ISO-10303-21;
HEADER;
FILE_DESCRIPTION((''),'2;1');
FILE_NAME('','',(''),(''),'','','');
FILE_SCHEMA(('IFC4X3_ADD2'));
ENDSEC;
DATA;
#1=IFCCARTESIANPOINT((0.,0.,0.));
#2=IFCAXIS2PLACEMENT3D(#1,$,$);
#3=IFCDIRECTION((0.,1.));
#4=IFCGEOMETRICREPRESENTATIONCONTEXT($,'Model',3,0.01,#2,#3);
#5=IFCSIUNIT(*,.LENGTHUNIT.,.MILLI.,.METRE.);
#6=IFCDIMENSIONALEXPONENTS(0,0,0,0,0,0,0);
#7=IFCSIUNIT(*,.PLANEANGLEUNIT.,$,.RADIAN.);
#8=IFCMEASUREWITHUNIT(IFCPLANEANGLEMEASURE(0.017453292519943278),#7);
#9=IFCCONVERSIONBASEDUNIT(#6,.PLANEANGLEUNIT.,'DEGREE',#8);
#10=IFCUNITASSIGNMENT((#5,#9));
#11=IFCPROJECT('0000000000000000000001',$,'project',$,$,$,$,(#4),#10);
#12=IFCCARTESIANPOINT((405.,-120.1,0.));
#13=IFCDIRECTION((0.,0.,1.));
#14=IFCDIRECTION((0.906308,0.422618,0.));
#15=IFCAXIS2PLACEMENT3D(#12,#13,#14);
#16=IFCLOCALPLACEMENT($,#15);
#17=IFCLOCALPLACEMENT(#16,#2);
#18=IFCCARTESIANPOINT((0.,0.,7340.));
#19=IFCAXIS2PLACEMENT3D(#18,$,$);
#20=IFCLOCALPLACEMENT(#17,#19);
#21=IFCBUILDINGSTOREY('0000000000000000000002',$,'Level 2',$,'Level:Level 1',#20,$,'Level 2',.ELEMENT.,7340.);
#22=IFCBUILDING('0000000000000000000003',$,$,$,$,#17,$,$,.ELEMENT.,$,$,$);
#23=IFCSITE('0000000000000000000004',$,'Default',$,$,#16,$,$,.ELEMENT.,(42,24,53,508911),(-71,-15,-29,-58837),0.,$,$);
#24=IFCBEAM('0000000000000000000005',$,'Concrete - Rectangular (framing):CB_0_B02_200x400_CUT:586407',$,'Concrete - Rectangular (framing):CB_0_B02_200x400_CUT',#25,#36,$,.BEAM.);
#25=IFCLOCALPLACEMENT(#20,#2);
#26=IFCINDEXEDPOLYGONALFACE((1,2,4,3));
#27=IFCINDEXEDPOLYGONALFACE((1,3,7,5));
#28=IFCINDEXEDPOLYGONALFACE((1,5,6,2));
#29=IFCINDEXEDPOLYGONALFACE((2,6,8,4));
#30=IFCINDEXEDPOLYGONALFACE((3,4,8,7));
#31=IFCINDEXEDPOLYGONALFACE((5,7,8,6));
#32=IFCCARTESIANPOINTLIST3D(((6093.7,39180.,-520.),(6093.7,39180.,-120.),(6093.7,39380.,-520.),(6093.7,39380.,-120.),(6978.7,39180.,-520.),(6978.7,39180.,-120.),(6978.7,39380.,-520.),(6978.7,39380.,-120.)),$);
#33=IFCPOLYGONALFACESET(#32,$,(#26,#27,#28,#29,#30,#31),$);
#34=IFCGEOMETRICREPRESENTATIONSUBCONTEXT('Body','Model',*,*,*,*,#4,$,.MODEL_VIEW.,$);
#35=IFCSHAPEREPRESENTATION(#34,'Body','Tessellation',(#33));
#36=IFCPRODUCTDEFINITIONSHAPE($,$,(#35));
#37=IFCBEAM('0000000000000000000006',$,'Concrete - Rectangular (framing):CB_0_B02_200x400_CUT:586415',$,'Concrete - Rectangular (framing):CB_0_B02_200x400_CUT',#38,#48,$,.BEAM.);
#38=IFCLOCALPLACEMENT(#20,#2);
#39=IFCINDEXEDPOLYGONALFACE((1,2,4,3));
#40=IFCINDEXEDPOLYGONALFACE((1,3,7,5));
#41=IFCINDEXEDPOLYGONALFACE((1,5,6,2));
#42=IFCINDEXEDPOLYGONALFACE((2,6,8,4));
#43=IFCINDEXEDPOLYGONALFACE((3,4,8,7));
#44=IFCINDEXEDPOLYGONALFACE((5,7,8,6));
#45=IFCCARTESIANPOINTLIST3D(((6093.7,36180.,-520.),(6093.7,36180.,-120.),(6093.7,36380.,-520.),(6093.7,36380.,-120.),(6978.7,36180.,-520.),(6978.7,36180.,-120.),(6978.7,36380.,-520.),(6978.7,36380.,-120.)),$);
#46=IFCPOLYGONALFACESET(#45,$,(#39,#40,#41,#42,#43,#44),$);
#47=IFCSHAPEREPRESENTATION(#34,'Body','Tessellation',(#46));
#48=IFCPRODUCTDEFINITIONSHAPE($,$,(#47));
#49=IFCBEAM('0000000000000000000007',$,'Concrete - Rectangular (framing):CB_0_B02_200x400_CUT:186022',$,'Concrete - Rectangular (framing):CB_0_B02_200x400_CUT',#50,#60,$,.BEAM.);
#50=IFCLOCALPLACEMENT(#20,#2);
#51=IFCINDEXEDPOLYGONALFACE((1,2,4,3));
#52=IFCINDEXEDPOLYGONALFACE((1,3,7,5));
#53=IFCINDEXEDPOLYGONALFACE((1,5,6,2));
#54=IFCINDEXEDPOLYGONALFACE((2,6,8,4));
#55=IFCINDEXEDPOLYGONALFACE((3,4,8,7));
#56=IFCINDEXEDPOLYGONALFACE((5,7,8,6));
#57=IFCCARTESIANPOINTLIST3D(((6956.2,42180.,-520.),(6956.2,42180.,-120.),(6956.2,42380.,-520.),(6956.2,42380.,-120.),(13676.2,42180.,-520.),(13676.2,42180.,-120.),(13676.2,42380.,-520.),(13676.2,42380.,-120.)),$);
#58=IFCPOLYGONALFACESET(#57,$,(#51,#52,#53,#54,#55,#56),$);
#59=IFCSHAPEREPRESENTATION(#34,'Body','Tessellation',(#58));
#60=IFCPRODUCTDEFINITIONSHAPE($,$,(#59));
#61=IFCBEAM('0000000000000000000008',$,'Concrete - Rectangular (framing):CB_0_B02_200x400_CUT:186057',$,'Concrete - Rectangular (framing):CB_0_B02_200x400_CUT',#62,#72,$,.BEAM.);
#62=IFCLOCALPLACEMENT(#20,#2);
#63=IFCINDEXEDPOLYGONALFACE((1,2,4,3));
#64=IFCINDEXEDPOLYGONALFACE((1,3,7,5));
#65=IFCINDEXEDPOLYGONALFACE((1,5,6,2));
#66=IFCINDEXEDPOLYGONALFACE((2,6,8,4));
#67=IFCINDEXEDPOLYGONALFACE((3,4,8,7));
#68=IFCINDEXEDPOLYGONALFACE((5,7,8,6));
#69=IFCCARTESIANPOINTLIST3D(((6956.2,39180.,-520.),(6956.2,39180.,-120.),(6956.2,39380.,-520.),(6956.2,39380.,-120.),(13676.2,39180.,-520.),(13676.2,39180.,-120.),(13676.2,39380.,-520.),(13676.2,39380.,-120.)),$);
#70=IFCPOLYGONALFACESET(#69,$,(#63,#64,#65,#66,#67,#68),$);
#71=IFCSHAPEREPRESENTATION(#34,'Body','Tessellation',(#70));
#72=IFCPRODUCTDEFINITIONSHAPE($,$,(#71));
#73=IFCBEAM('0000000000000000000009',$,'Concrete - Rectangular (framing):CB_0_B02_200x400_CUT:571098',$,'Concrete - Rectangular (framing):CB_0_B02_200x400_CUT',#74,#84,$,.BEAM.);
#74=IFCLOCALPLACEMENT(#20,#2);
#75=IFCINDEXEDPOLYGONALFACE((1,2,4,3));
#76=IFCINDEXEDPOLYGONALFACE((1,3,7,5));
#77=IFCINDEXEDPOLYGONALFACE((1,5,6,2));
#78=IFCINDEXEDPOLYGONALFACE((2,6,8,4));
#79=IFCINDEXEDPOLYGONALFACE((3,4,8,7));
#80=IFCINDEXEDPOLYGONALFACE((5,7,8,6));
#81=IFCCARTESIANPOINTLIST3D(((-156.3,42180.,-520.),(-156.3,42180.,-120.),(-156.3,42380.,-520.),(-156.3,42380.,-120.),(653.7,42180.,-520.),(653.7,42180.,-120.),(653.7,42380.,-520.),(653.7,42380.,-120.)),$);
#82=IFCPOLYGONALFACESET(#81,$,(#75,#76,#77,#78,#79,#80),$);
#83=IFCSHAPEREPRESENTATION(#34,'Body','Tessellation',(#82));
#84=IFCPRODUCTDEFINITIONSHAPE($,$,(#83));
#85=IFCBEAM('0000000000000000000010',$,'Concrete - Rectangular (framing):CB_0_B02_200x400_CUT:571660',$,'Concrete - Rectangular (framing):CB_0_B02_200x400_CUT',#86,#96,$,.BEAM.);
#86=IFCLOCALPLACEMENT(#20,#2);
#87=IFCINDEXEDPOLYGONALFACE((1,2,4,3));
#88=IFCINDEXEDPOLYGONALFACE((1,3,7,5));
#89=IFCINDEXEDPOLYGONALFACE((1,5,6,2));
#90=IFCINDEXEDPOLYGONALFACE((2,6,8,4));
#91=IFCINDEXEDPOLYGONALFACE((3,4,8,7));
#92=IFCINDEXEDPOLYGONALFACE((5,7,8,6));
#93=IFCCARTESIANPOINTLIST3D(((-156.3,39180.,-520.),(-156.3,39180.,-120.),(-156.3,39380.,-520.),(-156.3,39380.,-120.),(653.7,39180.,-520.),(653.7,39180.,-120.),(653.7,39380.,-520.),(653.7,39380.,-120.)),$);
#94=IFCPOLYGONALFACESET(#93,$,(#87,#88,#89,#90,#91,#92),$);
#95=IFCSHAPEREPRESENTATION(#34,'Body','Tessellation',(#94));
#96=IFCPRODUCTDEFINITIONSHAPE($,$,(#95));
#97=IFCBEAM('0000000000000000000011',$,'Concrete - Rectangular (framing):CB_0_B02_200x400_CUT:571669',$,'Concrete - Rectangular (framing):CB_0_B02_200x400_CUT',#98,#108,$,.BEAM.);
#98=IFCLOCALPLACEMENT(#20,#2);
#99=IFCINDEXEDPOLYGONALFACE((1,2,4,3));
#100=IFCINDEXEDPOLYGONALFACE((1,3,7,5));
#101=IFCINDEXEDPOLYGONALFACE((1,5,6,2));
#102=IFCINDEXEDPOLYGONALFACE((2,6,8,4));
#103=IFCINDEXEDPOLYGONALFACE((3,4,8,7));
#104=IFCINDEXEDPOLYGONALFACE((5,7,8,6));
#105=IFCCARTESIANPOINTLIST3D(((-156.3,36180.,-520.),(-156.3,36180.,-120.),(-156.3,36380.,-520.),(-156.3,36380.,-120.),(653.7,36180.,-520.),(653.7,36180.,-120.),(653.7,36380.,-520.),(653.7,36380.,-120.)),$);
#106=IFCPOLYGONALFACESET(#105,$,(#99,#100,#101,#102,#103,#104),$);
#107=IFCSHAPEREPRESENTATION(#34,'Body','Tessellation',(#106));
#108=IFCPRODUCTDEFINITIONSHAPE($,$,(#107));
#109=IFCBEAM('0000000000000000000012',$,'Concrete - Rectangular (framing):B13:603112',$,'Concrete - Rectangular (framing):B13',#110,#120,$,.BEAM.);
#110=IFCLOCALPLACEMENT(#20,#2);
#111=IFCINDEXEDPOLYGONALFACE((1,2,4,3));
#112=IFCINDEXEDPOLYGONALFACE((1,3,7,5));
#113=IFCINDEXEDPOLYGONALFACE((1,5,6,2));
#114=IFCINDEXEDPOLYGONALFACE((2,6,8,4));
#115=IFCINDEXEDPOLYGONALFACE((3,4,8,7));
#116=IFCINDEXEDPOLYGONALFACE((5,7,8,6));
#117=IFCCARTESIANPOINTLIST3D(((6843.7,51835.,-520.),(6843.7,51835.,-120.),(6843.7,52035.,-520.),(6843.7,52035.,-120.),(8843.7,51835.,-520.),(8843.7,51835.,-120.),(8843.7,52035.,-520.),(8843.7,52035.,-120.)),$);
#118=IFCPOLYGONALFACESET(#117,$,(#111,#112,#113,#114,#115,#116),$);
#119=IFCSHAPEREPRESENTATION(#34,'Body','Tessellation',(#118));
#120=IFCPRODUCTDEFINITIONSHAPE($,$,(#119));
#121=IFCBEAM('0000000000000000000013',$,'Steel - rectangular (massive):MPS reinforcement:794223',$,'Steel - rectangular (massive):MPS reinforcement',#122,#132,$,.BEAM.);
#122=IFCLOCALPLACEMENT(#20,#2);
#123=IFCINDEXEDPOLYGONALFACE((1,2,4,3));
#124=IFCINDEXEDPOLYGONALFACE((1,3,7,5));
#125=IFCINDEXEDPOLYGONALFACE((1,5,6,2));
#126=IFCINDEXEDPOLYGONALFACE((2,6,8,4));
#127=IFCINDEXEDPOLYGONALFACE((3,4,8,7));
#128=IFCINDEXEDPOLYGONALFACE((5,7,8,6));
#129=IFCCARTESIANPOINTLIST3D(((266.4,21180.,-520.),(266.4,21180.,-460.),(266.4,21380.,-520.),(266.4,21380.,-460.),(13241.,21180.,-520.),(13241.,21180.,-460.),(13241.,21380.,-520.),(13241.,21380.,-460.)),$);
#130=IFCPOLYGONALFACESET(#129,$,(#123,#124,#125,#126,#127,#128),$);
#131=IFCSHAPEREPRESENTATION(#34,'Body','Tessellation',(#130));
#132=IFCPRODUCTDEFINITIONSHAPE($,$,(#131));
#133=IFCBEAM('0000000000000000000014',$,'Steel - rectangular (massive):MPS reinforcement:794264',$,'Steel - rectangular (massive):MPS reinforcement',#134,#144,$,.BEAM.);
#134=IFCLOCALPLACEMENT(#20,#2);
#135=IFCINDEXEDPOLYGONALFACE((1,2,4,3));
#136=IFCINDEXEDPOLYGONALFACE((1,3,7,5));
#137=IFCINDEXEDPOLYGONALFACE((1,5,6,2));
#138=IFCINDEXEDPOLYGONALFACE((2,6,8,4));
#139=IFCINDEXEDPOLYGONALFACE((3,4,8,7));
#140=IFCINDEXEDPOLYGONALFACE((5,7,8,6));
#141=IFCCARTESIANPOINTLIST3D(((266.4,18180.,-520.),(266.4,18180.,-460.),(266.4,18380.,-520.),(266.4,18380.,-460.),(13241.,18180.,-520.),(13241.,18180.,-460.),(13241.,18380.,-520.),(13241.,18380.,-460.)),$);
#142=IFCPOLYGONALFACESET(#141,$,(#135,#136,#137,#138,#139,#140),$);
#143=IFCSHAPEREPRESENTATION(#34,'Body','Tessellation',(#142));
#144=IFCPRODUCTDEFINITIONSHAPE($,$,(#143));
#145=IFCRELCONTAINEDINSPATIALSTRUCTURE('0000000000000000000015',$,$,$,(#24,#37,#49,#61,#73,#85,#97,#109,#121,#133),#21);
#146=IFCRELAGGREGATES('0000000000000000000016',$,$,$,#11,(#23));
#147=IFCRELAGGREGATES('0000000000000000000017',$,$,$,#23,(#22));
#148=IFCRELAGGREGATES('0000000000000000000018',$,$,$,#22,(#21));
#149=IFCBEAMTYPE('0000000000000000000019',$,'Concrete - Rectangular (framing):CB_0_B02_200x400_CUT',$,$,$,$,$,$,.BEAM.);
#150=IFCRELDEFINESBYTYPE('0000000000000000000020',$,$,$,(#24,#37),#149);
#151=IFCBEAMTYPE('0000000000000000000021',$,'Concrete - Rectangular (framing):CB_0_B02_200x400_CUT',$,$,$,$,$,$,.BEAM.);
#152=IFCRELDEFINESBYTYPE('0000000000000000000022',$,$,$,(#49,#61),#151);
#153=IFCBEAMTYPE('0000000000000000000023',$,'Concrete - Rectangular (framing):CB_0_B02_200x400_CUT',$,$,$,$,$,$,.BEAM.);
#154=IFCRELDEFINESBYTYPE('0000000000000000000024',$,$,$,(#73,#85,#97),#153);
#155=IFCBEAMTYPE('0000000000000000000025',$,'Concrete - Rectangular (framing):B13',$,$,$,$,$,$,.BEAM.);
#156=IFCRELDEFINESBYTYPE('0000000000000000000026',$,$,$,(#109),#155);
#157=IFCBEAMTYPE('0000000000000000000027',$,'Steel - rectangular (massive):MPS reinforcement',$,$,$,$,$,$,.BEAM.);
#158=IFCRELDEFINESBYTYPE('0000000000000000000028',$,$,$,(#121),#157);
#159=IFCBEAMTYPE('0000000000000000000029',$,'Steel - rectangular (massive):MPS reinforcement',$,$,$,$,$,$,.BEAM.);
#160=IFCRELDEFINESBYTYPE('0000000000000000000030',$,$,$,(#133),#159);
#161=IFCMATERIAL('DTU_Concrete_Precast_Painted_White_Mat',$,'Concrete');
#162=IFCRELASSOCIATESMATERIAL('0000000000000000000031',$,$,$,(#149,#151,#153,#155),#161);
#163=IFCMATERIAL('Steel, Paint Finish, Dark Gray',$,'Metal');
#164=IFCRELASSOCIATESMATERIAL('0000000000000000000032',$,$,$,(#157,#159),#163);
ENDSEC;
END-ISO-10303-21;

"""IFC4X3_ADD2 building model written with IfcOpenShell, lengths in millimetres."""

from ifc_helpers import new_model, entity, si_unit, converted_unit, direction, frame, origin, origin_2d_with_axis, place, context, subcontext, project, spatial, rectangle, extrude, source, transform, mapped, material, material_profile, profile_set, type_object, type_shapes, element, save


model = new_model("IFC4X3_ADD2")

# Units and contexts
model_context = context("Model", 3, precision=0.01, world=origin(), true_north=direction((0.0, 1.0)))
body_context = subcontext(model_context, "Body", "Model", "MODEL_VIEW")
ifc_project = project(units=[si_unit("LENGTHUNIT", "METRE", prefix="MILLI"), converted_unit("PLANEANGLEUNIT", "DEGREE", entity("IfcPlaneAngleMeasure", 0.017453292519943278), si_unit("PLANEANGLEUNIT", "RADIAN"), dimensions=[0, 0, 0, 0, 0, 0, 0])], contexts=[model_context])

# Site, building, storey
site_placement = place(None, frame((405.0, -120.1, 0.0), z_axis=(0.0, 0.0, 1.0), x_axis=(0.906308, 0.422618, 0.0)))
site = spatial("IfcSite", under=ifc_project, at=site_placement, Name="Default", CompositionType="ELEMENT", RefLatitude=(42, 24, 53, 508911), RefLongitude=(-71, -15, -29, -58837), RefElevation=0.0)
building_placement = place(site_placement, origin())
building = spatial("IfcBuilding", under=site, at=building_placement, CompositionType="ELEMENT")
storey_placement = place(building_placement, frame((0.0, 0.0, 7340.0)))
storey = spatial("IfcBuildingStorey", under=building, at=storey_placement, Name="Level 2", ObjectType="Level:Level 1", LongName="Level 2", CompositionType="ELEMENT", Elevation=7340.0)

# Beams
ifc_material_1 = material(Name="DTU_Concrete_Precast_Painted_White_Mat", Category="Concrete")
ifc_material_profile_1 = material_profile(ifc_material_1, rectangle(XDim=885.0, YDim=200.0, at=origin_2d_with_axis()), Name="CB_0_B02_200x400_CUT")
ifc_profile_set_1 = profile_set([ifc_material_profile_1], Name="CB_0_B02_200x400_CUT")
beam_type_1 = type_object("IfcBeamType", Name="Concrete - Rectangular (framing):CB_0_B02_200x400_CUT", PredefinedType="BEAM", material=ifc_profile_set_1)
shared_shape_1 = source(origin(), body_context, "Body", "SweptSolid", [
    extrude(rectangle(XDim=885.0, YDim=200.0, at=origin_2d_with_axis()), frame((0.0, 0.0, -200.0), z_axis=(0.0, 0.0, 1.0), x_axis=(-1.0, 0.0, 0.0)), (0.0, 0.0, 1.0), 400.0),
])
type_shapes(beam_type_1, [shared_shape_1])
for number, where, z_axis, x_axis, name in (
    (1, (6536.2, 39280.0, -320.0), (0.0, 0.0, 1.0), (-1.0, 0.0, 0.0), "Concrete - Rectangular (framing):CB_0_B02_200x400_CUT:586407"),
    (2, (6536.2, 36280.0, -320.0), (0.0, 0.0, 1.0), (-1.0, 0.0, 0.0), "Concrete - Rectangular (framing):CB_0_B02_200x400_CUT:586415"),
):
    element("IfcBeam", number, at=place(storey_placement, frame(where, z_axis=z_axis, x_axis=x_axis)), inside=storey, type_object=beam_type_1, Name=name, ObjectType="Concrete - Rectangular (framing):CB_0_B02_200x400_CUT", PredefinedType="BEAM", context=body_context, shape_type="MappedRepresentation", body=[
        mapped(shared_shape_1, transform((0.0, 0.0, 0.0), scale=1.0)),
    ])
beam_type_2 = type_object("IfcBeamType", Name="Concrete - Rectangular (framing):CB_0_B02_200x400_CUT", PredefinedType="BEAM", material=ifc_profile_set_1)
shared_shape_2 = source(origin(), body_context, "Body", "SweptSolid", [
    extrude(rectangle(XDim=6720.0, YDim=200.0, at=origin_2d_with_axis()), frame((0.0, 0.0, -200.0), z_axis=(0.0, 0.0, 1.0), x_axis=(-1.0, 0.0, 0.0)), (0.0, 0.0, 1.0), 400.0),
])
type_shapes(beam_type_2, [shared_shape_2])
for number, where, name in (
    (3, (10316.2, 42280.0, -320.0), "Concrete - Rectangular (framing):CB_0_B02_200x400_CUT:186022"),
    (4, (10316.2, 39280.0, -320.0), "Concrete - Rectangular (framing):CB_0_B02_200x400_CUT:186057"),
):
    element("IfcBeam", number, at=place(storey_placement, frame(where)), inside=storey, type_object=beam_type_2, Name=name, ObjectType="Concrete - Rectangular (framing):CB_0_B02_200x400_CUT", PredefinedType="BEAM", context=body_context, shape_type="MappedRepresentation", body=[
        mapped(shared_shape_2, transform((0.0, 0.0, 0.0), scale=1.0)),
    ])
beam_type_3 = type_object("IfcBeamType", Name="Concrete - Rectangular (framing):CB_0_B02_200x400_CUT", PredefinedType="BEAM", material=ifc_profile_set_1)
shared_shape_3 = source(origin(), body_context, "Body", "SweptSolid", [
    extrude(rectangle(XDim=810.0, YDim=200.0, at=origin_2d_with_axis()), frame((0.0, 0.0, -200.0), z_axis=(0.0, 0.0, 1.0), x_axis=(-1.0, 0.0, 0.0)), (0.0, 0.0, 1.0), 400.0),
])
type_shapes(beam_type_3, [shared_shape_3])
for number, where, z_axis, x_axis, name in (
    (5, (248.7, 42280.0, -320.0), (0.0, 0.0, 1.0), (-1.0, 0.0, 0.0), "Concrete - Rectangular (framing):CB_0_B02_200x400_CUT:571098"),
    (6, (248.7, 39280.0, -320.0), (0.0, 0.0, 1.0), (-1.0, 0.0, 0.0), "Concrete - Rectangular (framing):CB_0_B02_200x400_CUT:571660"),
    (7, (248.7, 36280.0, -320.0), (0.0, 0.0, 1.0), (-1.0, 0.0, 0.0), "Concrete - Rectangular (framing):CB_0_B02_200x400_CUT:571669"),
):
    element("IfcBeam", number, at=place(storey_placement, frame(where, z_axis=z_axis, x_axis=x_axis)), inside=storey, type_object=beam_type_3, Name=name, ObjectType="Concrete - Rectangular (framing):CB_0_B02_200x400_CUT", PredefinedType="BEAM", context=body_context, shape_type="MappedRepresentation", body=[
        mapped(shared_shape_3, transform((0.0, 0.0, 0.0), scale=1.0)),
    ])
ifc_material_profile_2 = material_profile(ifc_material_1, rectangle(XDim=2000.0, YDim=200.0, at=origin_2d_with_axis()), Name="B13")
ifc_profile_set_2 = profile_set([ifc_material_profile_2], Name="B13")
beam_type_4 = type_object("IfcBeamType", Name="Concrete - Rectangular (framing):B13", PredefinedType="BEAM", material=ifc_profile_set_2)
shared_shape_4 = source(origin(), body_context, "Body", "SweptSolid", [
    extrude(rectangle(XDim=2000.0, YDim=200.0, at=origin_2d_with_axis()), frame((-7.5, 0.0, -200.0), z_axis=(0.0, 0.0, 1.0), x_axis=(-1.0, 0.0, 0.0)), (0.0, 0.0, 1.0), 400.0),
])
type_shapes(beam_type_4, [shared_shape_4])
beam_1_placement = place(storey_placement, frame((7836.2, 51935.0, -320.0), z_axis=(0.0, 0.0, 1.0), x_axis=(-1.0, 0.0, 0.0)))
element("IfcBeam", 8, at=beam_1_placement, inside=storey, type_object=beam_type_4, Name="Concrete - Rectangular (framing):B13:603112", ObjectType="Concrete - Rectangular (framing):B13", PredefinedType="BEAM", context=body_context, shape_type="MappedRepresentation", body=[
    mapped(shared_shape_4, transform((0.0, 0.0, 0.0), scale=1.0)),
])
ifc_material_2 = material(Name="Steel, Paint Finish, Dark Gray", Category="Metal")
ifc_material_profile_3 = material_profile(ifc_material_2, rectangle(XDim=12974.6, YDim=200.0, at=origin_2d_with_axis()), Name="MPS reinforcement")
ifc_profile_set_3 = profile_set([ifc_material_profile_3], Name="MPS reinforcement")
beam_type_5 = type_object("IfcBeamType", Name="Steel - rectangular (massive):MPS reinforcement", PredefinedType="BEAM", material=ifc_profile_set_3)
shared_shape_5 = source(origin(), body_context, "Body", "SweptSolid", [
    extrude(rectangle(XDim=12974.6, YDim=200.0, at=origin_2d_with_axis()), frame((0.0, 0.0, -30.0), z_axis=(0.0, 0.0, 1.0), x_axis=(-1.0, 0.0, 0.0)), (0.0, 0.0, 1.0), 60.0),
])
type_shapes(beam_type_5, [shared_shape_5])
beam_2_placement = place(storey_placement, frame((6753.7, 21280.0, -490.0)))
element("IfcBeam", 9, at=beam_2_placement, inside=storey, type_object=beam_type_5, Name="Steel - rectangular (massive):MPS reinforcement:794223", ObjectType="Steel - rectangular (massive):MPS reinforcement", PredefinedType="BEAM", context=body_context, shape_type="MappedRepresentation", body=[
    mapped(shared_shape_5, transform((0.0, 0.0, 0.0), scale=1.0)),
])
beam_type_6 = type_object("IfcBeamType", Name="Steel - rectangular (massive):MPS reinforcement", PredefinedType="BEAM", material=ifc_profile_set_3)
shared_shape_6 = source(origin(), body_context, "Body", "SweptSolid", [
    extrude(rectangle(XDim=12974.6, YDim=200.0, at=origin_2d_with_axis()), frame((-0.5, 0.0, -30.0), z_axis=(0.0, 0.0, 1.0), x_axis=(-1.0, 0.0, 0.0)), (0.0, 0.0, 1.0), 60.0),
])
type_shapes(beam_type_6, [shared_shape_6])
beam_3_placement = place(storey_placement, frame((6754.2, 18280.0, -490.0)))
element("IfcBeam", 10, at=beam_3_placement, inside=storey, type_object=beam_type_6, Name="Steel - rectangular (massive):MPS reinforcement:794264", ObjectType="Steel - rectangular (massive):MPS reinforcement", PredefinedType="BEAM", context=body_context, shape_type="MappedRepresentation", body=[
    mapped(shared_shape_6, transform((0.0, 0.0, 0.0), scale=1.0)),
])

save(model, "model.ifc")
